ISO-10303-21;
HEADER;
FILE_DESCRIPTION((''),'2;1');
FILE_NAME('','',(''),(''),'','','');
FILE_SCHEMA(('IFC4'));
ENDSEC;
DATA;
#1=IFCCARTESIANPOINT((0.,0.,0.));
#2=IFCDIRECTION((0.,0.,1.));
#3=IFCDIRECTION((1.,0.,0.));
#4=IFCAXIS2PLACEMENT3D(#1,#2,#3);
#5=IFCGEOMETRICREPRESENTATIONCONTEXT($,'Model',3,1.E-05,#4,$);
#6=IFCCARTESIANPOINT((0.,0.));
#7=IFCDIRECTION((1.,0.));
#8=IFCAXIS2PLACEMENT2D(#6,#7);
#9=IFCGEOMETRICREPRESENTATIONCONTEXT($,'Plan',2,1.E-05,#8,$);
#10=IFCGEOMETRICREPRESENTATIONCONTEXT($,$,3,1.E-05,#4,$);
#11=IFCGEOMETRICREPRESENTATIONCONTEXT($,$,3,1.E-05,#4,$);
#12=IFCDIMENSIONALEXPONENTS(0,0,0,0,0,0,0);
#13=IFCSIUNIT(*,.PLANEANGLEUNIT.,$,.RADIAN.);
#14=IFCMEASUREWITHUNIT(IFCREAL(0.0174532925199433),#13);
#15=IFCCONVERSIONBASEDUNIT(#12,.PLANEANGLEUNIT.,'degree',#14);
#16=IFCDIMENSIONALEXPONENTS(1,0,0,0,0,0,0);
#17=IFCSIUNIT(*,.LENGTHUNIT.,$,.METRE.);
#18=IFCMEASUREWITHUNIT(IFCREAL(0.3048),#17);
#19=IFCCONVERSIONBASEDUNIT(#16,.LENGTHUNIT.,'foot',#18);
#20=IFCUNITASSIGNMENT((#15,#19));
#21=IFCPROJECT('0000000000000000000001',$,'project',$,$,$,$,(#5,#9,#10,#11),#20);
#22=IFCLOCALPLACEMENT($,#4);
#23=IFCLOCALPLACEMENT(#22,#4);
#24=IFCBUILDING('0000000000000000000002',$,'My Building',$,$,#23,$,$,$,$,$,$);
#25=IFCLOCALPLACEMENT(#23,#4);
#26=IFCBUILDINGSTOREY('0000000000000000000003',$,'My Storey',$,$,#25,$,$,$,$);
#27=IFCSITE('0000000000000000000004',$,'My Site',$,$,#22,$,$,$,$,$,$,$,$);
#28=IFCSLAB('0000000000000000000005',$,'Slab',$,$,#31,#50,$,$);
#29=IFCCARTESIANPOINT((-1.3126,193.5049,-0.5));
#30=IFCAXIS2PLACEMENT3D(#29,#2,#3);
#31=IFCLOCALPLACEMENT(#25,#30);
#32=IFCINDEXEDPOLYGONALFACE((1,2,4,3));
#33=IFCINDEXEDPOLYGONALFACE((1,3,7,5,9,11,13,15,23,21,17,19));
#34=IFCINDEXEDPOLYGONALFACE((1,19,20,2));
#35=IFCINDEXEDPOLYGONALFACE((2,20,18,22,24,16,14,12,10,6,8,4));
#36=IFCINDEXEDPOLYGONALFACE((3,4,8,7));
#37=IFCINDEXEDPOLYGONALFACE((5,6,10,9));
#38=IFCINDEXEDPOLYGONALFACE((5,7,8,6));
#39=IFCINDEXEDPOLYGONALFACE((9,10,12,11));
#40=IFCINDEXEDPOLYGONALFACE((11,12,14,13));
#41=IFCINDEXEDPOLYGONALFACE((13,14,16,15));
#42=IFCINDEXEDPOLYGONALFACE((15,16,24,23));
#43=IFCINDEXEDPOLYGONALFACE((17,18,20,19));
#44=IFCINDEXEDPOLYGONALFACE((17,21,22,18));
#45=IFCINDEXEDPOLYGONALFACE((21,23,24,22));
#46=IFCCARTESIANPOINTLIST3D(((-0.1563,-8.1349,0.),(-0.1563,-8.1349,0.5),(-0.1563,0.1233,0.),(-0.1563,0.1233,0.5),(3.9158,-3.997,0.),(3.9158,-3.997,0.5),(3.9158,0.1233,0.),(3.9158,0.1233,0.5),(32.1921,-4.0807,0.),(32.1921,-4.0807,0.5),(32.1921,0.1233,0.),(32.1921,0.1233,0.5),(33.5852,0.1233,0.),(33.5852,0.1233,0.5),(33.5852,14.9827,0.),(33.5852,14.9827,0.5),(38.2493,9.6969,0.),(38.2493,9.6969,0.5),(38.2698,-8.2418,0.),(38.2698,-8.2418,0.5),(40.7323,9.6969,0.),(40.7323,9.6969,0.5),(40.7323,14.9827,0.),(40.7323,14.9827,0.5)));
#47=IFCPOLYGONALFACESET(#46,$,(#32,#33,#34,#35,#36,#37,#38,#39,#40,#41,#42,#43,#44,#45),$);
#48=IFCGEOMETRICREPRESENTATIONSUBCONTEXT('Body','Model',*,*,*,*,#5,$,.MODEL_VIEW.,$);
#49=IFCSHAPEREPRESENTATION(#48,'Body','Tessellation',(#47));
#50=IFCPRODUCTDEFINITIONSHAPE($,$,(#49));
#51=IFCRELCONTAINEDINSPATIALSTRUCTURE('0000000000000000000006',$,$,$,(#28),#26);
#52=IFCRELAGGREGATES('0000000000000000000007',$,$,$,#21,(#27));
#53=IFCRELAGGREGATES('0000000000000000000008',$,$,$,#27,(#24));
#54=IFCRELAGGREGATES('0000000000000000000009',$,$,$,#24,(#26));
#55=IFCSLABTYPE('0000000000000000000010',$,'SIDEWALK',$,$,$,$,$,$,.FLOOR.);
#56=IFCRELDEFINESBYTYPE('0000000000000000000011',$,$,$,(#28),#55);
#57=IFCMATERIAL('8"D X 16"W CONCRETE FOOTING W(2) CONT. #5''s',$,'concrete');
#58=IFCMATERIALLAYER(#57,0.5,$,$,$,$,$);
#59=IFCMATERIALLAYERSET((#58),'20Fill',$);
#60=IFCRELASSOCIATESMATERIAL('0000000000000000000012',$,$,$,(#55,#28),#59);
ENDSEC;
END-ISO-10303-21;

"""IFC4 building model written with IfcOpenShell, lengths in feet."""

from ifc_helpers import new_model, entity, si_unit, converted_unit, frame, origin_with_axes, origin_2d_with_axis, place, context, subcontext, project, spatial, line, indexed_curve, outline, extrude, material, layer, layer_set, layer_usage, type_object, element, save


model = new_model("IFC4")

# Units and contexts
model_context = context("Model", 3, precision=1e-05, world=origin_with_axes())
plan_context = context("Plan", 2, precision=1e-05, world=origin_2d_with_axis())
context_of_model_1 = context(None, 3, precision=1e-05, world=origin_with_axes())
context_of_model_2 = context(None, 3, precision=1e-05, world=origin_with_axes())
body_context = subcontext(model_context, "Body", "Model", "MODEL_VIEW")
ifc_project = project(units=[converted_unit("PLANEANGLEUNIT", "degree", entity("IfcReal", 0.0174532925199433), si_unit("PLANEANGLEUNIT", "RADIAN"), dimensions=[0, 0, 0, 0, 0, 0, 0]), converted_unit("LENGTHUNIT", "foot", entity("IfcReal", 0.3048), si_unit("LENGTHUNIT", "METRE"), dimensions=[1, 0, 0, 0, 0, 0, 0])], contexts=[model_context, plan_context, context_of_model_1, context_of_model_2])

# Site, building, storey
site_placement = place(None, origin_with_axes())
site = spatial("IfcSite", under=ifc_project, at=site_placement, Name="My Site")
building_placement = place(site_placement, origin_with_axes())
building = spatial("IfcBuilding", under=site, at=building_placement, Name="My Building")
storey_placement = place(building_placement, origin_with_axes())
storey = spatial("IfcBuildingStorey", under=building, at=storey_placement, Name="My Storey")

# Slab
ifc_material_1 = material(Name="8\"D X 16\"W CONCRETE FOOTING W(2) CONT. #5's", Category="concrete")
ifc_layer_1 = layer(ifc_material_1, 0.5)
ifc_layer_set_1 = layer_set([ifc_layer_1], Name="20Fill")
ifc_layer_usage_1 = layer_usage(ifc_layer_set_1, "AXIS3", "POSITIVE", 0.0)
slab_type_1 = type_object("IfcSlabType", Name="SIDEWALK", PredefinedType="FLOOR", material=ifc_layer_set_1)
slab_1_placement = place(storey_placement, frame((-1.3126, 193.5049, -0.5), z_axis=(0.0, 0.0, 1.0), x_axis=(1.0, 0.0, 0.0)))
element("IfcSlab", 1, at=slab_1_placement, inside=storey, type_object=slab_type_1, material=ifc_layer_usage_1, Name="Slab", context=body_context, shape_type="SweptSolid", body=[
    extrude(outline(indexed_curve([(38.2493, 9.6969), (40.7323, 9.6969), (40.7323, 14.9827), (33.5852, 14.9827), (33.5852, 0.1233), (32.1921, 0.1233), (32.1921, -4.0807), (3.9158, -3.997), (3.9158, 0.1233), (-0.1563, 0.1233), (-0.1563, -8.1349), (38.2698, -8.2418)], segments=[line(10, 9), line(9, 8), line(8, 7), line(7, 6), line(6, 5), line(5, 4), line(4, 3), line(3, 2), line(2, 1), line(1, 12), line(12, 11), line(11, 10)], self_intersect=False)), None, (0.0, 0.0, 1.0), 0.5),
])

save(model, "model.ifc")
